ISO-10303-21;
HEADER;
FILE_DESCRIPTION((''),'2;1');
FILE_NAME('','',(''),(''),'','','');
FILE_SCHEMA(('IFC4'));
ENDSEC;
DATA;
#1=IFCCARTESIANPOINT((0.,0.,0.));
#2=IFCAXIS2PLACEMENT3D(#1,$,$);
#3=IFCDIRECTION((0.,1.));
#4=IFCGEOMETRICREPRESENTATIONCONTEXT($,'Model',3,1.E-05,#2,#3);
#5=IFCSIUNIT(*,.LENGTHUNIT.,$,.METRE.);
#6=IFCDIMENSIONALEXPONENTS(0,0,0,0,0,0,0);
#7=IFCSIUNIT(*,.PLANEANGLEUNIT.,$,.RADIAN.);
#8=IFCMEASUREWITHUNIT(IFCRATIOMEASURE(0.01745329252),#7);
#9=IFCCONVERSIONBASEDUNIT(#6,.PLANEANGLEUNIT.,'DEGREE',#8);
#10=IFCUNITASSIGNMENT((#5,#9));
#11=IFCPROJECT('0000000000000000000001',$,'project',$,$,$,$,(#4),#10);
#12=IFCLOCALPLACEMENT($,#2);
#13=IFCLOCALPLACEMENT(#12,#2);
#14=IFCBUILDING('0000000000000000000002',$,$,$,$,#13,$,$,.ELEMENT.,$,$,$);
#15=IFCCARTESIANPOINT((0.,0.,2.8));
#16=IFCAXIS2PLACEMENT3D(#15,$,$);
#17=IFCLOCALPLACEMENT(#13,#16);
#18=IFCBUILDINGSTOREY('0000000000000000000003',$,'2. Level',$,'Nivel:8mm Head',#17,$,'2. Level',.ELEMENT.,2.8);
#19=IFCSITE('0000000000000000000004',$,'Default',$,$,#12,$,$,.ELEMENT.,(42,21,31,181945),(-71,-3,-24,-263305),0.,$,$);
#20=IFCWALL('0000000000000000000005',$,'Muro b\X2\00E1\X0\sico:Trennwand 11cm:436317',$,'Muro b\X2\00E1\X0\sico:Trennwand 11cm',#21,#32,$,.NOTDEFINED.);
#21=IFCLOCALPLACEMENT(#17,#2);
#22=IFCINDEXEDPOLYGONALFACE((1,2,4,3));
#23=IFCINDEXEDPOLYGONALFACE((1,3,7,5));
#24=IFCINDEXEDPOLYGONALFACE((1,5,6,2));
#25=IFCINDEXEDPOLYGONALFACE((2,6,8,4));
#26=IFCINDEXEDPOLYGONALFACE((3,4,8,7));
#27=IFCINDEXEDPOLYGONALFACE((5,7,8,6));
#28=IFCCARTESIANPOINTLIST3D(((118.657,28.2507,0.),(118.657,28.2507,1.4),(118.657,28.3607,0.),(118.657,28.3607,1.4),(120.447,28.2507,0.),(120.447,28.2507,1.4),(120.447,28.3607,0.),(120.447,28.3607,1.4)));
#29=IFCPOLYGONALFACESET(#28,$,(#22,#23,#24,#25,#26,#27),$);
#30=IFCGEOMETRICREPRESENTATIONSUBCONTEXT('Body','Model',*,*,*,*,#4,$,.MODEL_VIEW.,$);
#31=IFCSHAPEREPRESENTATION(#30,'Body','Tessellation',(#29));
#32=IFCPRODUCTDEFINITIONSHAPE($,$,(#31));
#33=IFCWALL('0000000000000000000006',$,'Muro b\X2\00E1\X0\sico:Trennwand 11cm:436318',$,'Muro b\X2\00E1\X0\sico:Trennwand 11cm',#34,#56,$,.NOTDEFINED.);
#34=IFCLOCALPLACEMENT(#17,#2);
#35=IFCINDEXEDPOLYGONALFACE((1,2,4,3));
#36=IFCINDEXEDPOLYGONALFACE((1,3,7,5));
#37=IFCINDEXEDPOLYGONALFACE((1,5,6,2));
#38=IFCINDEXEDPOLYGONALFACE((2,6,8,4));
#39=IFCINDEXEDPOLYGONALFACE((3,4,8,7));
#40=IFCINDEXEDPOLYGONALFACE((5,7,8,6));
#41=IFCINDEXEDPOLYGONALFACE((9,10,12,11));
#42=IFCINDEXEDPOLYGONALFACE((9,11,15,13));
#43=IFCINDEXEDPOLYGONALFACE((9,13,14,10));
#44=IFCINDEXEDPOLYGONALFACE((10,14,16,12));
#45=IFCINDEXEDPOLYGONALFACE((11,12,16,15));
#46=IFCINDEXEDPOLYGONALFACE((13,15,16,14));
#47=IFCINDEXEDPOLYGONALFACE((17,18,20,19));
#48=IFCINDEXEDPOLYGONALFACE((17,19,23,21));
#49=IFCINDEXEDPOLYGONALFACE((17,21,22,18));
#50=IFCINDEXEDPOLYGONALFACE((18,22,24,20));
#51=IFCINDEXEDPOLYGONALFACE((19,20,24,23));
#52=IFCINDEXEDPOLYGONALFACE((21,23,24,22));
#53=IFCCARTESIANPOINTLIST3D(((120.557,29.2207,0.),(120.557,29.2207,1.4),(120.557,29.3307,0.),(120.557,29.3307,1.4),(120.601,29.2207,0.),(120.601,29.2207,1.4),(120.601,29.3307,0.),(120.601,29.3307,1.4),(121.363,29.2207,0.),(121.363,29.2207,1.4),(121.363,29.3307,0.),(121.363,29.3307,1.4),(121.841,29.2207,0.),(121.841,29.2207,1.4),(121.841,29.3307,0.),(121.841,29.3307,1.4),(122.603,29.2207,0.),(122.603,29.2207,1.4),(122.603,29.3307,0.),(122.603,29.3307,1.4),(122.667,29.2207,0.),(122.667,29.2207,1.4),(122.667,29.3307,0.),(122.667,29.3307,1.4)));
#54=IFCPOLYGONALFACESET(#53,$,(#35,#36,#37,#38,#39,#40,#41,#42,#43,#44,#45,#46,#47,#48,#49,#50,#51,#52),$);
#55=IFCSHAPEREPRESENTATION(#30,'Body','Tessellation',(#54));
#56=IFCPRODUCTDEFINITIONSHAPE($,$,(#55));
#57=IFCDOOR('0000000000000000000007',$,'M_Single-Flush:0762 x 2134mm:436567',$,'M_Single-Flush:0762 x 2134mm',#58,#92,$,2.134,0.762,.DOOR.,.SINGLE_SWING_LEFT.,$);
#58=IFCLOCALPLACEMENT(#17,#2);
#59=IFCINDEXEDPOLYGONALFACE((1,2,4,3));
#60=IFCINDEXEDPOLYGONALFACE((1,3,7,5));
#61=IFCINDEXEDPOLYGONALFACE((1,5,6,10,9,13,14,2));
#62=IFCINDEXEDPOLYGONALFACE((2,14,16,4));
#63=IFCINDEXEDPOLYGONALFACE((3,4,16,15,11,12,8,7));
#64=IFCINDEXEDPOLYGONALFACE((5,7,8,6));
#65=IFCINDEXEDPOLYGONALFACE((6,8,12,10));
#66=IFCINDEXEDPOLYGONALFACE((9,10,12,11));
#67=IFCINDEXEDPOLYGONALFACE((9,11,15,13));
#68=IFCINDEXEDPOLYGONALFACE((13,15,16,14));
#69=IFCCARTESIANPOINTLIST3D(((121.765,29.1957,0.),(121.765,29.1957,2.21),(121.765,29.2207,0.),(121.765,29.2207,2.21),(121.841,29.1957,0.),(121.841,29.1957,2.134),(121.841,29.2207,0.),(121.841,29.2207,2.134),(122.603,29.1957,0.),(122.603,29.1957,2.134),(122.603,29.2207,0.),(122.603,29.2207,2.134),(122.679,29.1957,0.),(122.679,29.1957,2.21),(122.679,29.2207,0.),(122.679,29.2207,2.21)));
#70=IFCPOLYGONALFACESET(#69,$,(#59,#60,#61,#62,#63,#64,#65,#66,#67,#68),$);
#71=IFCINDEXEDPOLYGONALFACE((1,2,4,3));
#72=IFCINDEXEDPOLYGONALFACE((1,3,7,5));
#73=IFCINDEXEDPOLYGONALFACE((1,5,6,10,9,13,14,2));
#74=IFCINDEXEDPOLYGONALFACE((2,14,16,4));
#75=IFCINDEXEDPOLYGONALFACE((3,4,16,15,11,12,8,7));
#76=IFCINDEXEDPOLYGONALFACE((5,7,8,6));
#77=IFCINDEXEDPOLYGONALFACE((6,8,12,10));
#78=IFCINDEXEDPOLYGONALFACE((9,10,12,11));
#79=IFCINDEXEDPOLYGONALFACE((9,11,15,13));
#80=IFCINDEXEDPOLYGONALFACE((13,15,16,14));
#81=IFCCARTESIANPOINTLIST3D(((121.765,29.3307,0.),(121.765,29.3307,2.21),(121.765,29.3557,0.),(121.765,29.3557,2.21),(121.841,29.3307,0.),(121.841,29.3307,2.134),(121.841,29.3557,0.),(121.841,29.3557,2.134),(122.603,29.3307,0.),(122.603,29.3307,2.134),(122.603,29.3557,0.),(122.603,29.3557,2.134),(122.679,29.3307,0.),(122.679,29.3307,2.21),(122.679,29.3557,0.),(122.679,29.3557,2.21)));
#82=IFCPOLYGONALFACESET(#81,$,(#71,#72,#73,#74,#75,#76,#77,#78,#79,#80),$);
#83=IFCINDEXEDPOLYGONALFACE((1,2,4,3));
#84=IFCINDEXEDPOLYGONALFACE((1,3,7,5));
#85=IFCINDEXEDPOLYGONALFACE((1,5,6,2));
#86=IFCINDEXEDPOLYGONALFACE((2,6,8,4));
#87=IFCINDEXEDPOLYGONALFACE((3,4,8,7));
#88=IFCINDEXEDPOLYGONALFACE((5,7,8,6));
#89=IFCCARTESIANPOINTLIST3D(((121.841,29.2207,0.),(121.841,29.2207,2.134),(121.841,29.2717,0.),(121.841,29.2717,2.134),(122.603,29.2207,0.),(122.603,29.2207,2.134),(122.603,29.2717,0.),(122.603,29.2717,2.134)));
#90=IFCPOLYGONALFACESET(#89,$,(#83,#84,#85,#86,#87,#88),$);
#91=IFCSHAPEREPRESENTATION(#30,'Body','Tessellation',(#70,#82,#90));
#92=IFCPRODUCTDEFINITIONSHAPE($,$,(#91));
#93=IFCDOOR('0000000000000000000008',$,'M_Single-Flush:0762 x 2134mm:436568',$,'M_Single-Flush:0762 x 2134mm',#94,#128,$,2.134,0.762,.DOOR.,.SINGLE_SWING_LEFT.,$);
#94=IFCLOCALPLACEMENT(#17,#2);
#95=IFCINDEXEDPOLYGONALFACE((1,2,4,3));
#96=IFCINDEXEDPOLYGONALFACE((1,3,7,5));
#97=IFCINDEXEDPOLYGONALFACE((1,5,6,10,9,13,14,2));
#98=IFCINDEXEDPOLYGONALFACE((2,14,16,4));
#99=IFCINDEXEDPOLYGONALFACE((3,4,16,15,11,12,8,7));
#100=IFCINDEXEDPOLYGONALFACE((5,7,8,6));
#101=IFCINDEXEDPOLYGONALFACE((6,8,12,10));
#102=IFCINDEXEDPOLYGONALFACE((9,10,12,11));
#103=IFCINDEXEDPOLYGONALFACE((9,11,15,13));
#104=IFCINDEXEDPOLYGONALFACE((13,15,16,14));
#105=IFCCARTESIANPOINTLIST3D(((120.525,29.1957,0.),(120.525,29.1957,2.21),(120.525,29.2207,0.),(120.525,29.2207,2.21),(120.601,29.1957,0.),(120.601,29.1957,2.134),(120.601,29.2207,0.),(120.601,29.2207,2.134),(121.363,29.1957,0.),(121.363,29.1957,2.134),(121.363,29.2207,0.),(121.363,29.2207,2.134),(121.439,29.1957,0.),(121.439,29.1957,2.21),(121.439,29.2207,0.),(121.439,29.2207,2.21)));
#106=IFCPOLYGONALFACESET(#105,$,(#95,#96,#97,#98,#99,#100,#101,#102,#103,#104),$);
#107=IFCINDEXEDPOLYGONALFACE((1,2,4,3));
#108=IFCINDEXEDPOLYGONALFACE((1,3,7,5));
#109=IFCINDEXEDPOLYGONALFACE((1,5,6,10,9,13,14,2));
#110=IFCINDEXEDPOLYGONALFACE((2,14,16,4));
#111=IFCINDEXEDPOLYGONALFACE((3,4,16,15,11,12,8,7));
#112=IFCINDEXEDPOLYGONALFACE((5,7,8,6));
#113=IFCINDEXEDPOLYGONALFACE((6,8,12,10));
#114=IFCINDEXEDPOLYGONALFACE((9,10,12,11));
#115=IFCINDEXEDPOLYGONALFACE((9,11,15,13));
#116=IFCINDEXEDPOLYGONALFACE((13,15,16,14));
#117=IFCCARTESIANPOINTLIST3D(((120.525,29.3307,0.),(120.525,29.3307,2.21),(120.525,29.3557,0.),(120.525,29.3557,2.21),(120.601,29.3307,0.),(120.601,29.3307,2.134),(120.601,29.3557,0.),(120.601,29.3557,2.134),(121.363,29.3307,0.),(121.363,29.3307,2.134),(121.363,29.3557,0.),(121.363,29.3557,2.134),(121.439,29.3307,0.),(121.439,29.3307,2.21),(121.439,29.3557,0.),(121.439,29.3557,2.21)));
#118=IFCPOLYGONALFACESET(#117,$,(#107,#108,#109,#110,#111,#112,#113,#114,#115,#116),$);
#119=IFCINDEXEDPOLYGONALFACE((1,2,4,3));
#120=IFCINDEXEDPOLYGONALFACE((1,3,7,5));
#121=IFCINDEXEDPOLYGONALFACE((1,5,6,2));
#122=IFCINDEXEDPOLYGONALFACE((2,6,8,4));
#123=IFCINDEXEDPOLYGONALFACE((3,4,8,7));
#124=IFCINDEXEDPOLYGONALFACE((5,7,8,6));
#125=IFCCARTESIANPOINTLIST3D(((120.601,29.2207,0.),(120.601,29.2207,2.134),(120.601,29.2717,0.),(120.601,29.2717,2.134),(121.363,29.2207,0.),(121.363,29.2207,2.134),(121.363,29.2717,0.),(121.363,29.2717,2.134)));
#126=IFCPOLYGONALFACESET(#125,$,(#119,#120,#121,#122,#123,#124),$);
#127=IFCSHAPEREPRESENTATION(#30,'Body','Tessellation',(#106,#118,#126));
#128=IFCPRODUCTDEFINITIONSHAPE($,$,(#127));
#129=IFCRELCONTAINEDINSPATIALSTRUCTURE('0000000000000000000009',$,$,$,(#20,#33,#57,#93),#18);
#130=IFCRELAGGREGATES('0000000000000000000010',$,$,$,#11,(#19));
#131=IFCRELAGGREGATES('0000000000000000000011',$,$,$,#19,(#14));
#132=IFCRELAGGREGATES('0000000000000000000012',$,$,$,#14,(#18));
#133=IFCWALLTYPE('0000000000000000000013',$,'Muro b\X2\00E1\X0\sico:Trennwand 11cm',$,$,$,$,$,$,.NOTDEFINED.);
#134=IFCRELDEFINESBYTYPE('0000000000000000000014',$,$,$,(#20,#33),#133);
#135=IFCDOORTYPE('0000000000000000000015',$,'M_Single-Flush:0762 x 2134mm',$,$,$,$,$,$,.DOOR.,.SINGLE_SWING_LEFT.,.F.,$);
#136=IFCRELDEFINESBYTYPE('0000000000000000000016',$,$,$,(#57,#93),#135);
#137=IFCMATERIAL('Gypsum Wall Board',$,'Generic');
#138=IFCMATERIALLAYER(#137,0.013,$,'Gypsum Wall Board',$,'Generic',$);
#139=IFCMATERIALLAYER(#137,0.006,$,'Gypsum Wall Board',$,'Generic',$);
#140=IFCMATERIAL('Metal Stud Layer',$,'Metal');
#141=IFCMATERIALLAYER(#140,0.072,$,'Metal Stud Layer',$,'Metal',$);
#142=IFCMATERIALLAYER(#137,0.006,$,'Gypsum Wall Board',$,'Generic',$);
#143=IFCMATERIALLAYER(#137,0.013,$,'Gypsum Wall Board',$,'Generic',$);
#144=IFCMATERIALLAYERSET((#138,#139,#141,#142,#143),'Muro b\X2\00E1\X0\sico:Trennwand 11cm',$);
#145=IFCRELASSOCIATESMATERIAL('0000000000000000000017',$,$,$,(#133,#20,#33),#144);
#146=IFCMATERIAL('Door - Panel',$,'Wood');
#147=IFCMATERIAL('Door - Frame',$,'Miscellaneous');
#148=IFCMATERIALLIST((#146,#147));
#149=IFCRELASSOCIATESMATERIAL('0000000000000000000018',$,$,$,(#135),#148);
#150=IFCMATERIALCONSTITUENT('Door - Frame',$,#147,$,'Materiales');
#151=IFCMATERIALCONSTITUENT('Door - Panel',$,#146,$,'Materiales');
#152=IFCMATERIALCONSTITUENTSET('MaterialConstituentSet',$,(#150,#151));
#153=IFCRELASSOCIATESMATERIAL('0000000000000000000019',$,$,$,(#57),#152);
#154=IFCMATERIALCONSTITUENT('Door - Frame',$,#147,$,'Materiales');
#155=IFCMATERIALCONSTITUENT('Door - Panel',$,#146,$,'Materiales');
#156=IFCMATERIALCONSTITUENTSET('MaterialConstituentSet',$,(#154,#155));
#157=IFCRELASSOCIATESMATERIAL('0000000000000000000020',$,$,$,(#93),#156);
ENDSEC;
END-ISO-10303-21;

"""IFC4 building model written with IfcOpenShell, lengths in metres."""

from ifc_helpers import new_model, entity, si_unit, converted_unit, direction, frame, frame_2d, origin, origin_2d_with_axis, place, context, subcontext, project, spatial, polyline, rectangle, outline, extrude, clip, halfspace, source, transform, mapped, material, material_list, layer, layer_set, layer_usage, constituent, constituent_set, type_object, type_shapes, element, fill, save


model = new_model("IFC4")

# Units and contexts
model_context = context("Model", 3, precision=1e-05, world=origin(), true_north=direction((0.0, 1.0)))
body_context = subcontext(model_context, "Body", "Model", "MODEL_VIEW")
ifc_project = project(units=[si_unit("LENGTHUNIT", "METRE"), converted_unit("PLANEANGLEUNIT", "DEGREE", entity("IfcRatioMeasure", 0.01745329252), si_unit("PLANEANGLEUNIT", "RADIAN"), dimensions=[0, 0, 0, 0, 0, 0, 0])], contexts=[model_context])

# Site, building, storey
site_placement = place(None, origin())
site = spatial("IfcSite", under=ifc_project, at=site_placement, Name="Default", CompositionType="ELEMENT", RefLatitude=(42, 21, 31, 181945), RefLongitude=(-71, -3, -24, -263305), RefElevation=0.0)
building_placement = place(site_placement, origin())
building = spatial("IfcBuilding", under=site, at=building_placement, CompositionType="ELEMENT")
storey_placement = place(building_placement, frame((0.0, 0.0, 2.8)))
storey = spatial("IfcBuildingStorey", under=building, at=storey_placement, Name="2. Level", ObjectType="Nivel:8mm Head", LongName="2. Level", CompositionType="ELEMENT", Elevation=2.8)

# Shared definitions
ifc_material_1 = material(Name="Gypsum Wall Board", Category="Generic")
ifc_layer_1 = layer(ifc_material_1, 0.013, Name="Gypsum Wall Board", Category="Generic")
ifc_layer_2 = layer(ifc_material_1, 0.006, Name="Gypsum Wall Board", Category="Generic")
ifc_material_2 = material(Name="Metal Stud Layer", Category="Metal")
ifc_layer_3 = layer(ifc_material_2, 0.072, Name="Metal Stud Layer", Category="Metal")
ifc_layer_4 = layer(ifc_material_1, 0.006, Name="Gypsum Wall Board", Category="Generic")
ifc_layer_5 = layer(ifc_material_1, 0.013, Name="Gypsum Wall Board", Category="Generic")
ifc_layer_set_1 = layer_set([ifc_layer_1, ifc_layer_2, ifc_layer_3, ifc_layer_4, ifc_layer_5], Name="Muro básico:Trennwand 11cm")
wall_type_1 = type_object("IfcWallType", Name="Muro básico:Trennwand 11cm", PredefinedType="NOTDEFINED", material=ifc_layer_set_1)
ifc_material_3 = material(Name="Door - Frame", Category="Miscellaneous")
ifc_material_4 = material(Name="Door - Panel", Category="Wood")
ifc_material_list_1 = material_list([ifc_material_4, ifc_material_3])
door_type_1 = type_object("IfcDoorType", Name="M_Single-Flush:0762 x 2134mm", OperationType="SINGLE_SWING_LEFT", ParameterTakesPrecedence=False, PredefinedType="DOOR", material=ifc_material_list_1)
shared_shape_1 = source(origin(), body_context, "Body", "SweptSolid", [
    extrude(outline(polyline([(-0.457, -1.124), (0.457, -1.124), (0.457, 1.086), (0.381, 1.086), (0.381, -1.048), (-0.381, -1.048), (-0.381, 1.086), (-0.457, 1.086), (-0.457, -1.124)])), frame((0.381, 0.135, 1.086), z_axis=(0.0, -1.0, 0.0), x_axis=(-1.0, 0.0, 0.0)), (0.0, 0.0, 1.0), 0.025),
    extrude(outline(polyline([(-1.124, -0.457), (1.086, -0.457), (1.086, -0.381), (-1.048, -0.381), (-1.048, 0.381), (1.086, 0.381), (1.086, 0.457), (-1.124, 0.457), (-1.124, -0.457)])), frame((0.381, 0.0, 1.086), z_axis=(0.0, -1.0, 0.0), x_axis=(0.0, 0.0, -1.0)), (0.0, 0.0, 1.0), 0.025),
    extrude(rectangle(XDim=0.762, YDim=0.051, at=origin_2d_with_axis()), frame((0.381, 0.0845, 0.0)), (0.0, 0.0, 1.0), 2.134),
])
type_shapes(door_type_1, [shared_shape_1])

# Wall
ifc_layer_usage_1 = layer_usage(ifc_layer_set_1, "AXIS2", "NEGATIVE", 0.055)
wall_1_placement = place(storey_placement, frame((120.447, 28.3057, 0.0), z_axis=(0.0, 0.0, 1.0), x_axis=(-1.0, 0.0, 0.0)))
element("IfcWall", 1, at=wall_1_placement, inside=storey, type_object=wall_type_1, material=ifc_layer_usage_1, Name="Muro básico:Trennwand 11cm:436317", ObjectType="Muro básico:Trennwand 11cm", PredefinedType="NOTDEFINED", context=body_context, shape_type="Clipping", body=[
    clip(extrude(rectangle(XDim=1.79, YDim=0.11, at=frame_2d((0.895, 0.0), x_axis=(-1.0, 0.0))), origin(), (0.0, 0.0, 1.0), 1.4), halfspace(origin(), True)),
])

# Wall, openings, doors
ifc_layer_usage_2 = layer_usage(ifc_layer_set_1, "AXIS2", "NEGATIVE", 0.055)
wall_2_placement = place(storey_placement, frame((120.557, 29.2757, 0.0)))
wall_2 = element("IfcWall", 2, at=wall_2_placement, inside=storey, type_object=wall_type_1, material=ifc_layer_usage_2, Name="Muro básico:Trennwand 11cm:436318", ObjectType="Muro básico:Trennwand 11cm", PredefinedType="NOTDEFINED", context=body_context, shape_type="Clipping", body=[
    clip(extrude(rectangle(XDim=2.11, YDim=0.11, at=frame_2d((1.055, 0.0), x_axis=(-1.0, 0.0))), origin(), (0.0, 0.0, 1.0), 1.4), halfspace(origin(), True)),
])
opening_1_placement = place(wall_2_placement, frame((2.046, 0.055, 0.0)))
opening_1 = element("IfcOpeningElement", 3, at=opening_1_placement, cuts=wall_2, ObjectType="Opening", PredefinedType="OPENING", context=body_context, shape_type="SweptSolid", body=[
    extrude(rectangle(XDim=0.762, YDim=2.134, at=frame_2d((1.067, 0.381), x_axis=(0.0, -1.0))), frame((0.0, 0.0, 0.0), z_axis=(0.0, -1.0, 0.0), x_axis=(0.0, 0.0, 1.0)), (0.0, 0.0, 1.0), 0.11),
])
opening_2_placement = place(wall_2_placement, frame((0.806, 0.055, 0.0)))
opening_2 = element("IfcOpeningElement", 4, at=opening_2_placement, cuts=wall_2, ObjectType="Opening", PredefinedType="OPENING", context=body_context, shape_type="SweptSolid", body=[
    extrude(rectangle(XDim=0.762, YDim=2.134, at=frame_2d((1.067, 0.381), x_axis=(0.0, -1.0))), frame((0.0, 0.0, 0.0), z_axis=(0.0, -1.0, 0.0), x_axis=(0.0, 0.0, 1.0)), (0.0, 0.0, 1.0), 0.11),
])
ifc_constituent_1 = constituent(ifc_material_3, Name="Door - Frame", Category="Materiales")
ifc_constituent_2 = constituent(ifc_material_4, Name="Door - Panel", Category="Materiales")
ifc_constituent_set_1 = constituent_set(constituents=[ifc_constituent_1, ifc_constituent_2], Name="MaterialConstituentSet")
door_1_placement = place(opening_1_placement, frame((0.0, 0.0, 0.0), z_axis=(0.0, 0.0, 1.0), x_axis=(-1.0, 0.0, 0.0)))
door_1 = element("IfcDoor", 5, at=door_1_placement, inside=storey, type_object=door_type_1, material=ifc_constituent_set_1, Name="M_Single-Flush:0762 x 2134mm:436567", ObjectType="M_Single-Flush:0762 x 2134mm", OperationType="SINGLE_SWING_LEFT", OverallHeight=2.134, OverallWidth=0.762, PredefinedType="DOOR", context=body_context, shape_type="MappedRepresentation", body=[
    mapped(shared_shape_1, transform((0.0, 0.0, 0.0), scale=1.0)),
])
fill(opening_1, door_1)
ifc_constituent_3 = constituent(ifc_material_3, Name="Door - Frame", Category="Materiales")
ifc_constituent_4 = constituent(ifc_material_4, Name="Door - Panel", Category="Materiales")
ifc_constituent_set_2 = constituent_set(constituents=[ifc_constituent_3, ifc_constituent_4], Name="MaterialConstituentSet")
door_2_placement = place(opening_2_placement, frame((0.0, 0.0, 0.0), z_axis=(0.0, 0.0, 1.0), x_axis=(-1.0, 0.0, 0.0)))
door_2 = element("IfcDoor", 6, at=door_2_placement, inside=storey, type_object=door_type_1, material=ifc_constituent_set_2, Name="M_Single-Flush:0762 x 2134mm:436568", ObjectType="M_Single-Flush:0762 x 2134mm", OperationType="SINGLE_SWING_LEFT", OverallHeight=2.134, OverallWidth=0.762, PredefinedType="DOOR", context=body_context, shape_type="MappedRepresentation", body=[
    mapped(shared_shape_1, transform((0.0, 0.0, 0.0), scale=1.0)),
])
fill(opening_2, door_2)

save(model, "model.ifc")
